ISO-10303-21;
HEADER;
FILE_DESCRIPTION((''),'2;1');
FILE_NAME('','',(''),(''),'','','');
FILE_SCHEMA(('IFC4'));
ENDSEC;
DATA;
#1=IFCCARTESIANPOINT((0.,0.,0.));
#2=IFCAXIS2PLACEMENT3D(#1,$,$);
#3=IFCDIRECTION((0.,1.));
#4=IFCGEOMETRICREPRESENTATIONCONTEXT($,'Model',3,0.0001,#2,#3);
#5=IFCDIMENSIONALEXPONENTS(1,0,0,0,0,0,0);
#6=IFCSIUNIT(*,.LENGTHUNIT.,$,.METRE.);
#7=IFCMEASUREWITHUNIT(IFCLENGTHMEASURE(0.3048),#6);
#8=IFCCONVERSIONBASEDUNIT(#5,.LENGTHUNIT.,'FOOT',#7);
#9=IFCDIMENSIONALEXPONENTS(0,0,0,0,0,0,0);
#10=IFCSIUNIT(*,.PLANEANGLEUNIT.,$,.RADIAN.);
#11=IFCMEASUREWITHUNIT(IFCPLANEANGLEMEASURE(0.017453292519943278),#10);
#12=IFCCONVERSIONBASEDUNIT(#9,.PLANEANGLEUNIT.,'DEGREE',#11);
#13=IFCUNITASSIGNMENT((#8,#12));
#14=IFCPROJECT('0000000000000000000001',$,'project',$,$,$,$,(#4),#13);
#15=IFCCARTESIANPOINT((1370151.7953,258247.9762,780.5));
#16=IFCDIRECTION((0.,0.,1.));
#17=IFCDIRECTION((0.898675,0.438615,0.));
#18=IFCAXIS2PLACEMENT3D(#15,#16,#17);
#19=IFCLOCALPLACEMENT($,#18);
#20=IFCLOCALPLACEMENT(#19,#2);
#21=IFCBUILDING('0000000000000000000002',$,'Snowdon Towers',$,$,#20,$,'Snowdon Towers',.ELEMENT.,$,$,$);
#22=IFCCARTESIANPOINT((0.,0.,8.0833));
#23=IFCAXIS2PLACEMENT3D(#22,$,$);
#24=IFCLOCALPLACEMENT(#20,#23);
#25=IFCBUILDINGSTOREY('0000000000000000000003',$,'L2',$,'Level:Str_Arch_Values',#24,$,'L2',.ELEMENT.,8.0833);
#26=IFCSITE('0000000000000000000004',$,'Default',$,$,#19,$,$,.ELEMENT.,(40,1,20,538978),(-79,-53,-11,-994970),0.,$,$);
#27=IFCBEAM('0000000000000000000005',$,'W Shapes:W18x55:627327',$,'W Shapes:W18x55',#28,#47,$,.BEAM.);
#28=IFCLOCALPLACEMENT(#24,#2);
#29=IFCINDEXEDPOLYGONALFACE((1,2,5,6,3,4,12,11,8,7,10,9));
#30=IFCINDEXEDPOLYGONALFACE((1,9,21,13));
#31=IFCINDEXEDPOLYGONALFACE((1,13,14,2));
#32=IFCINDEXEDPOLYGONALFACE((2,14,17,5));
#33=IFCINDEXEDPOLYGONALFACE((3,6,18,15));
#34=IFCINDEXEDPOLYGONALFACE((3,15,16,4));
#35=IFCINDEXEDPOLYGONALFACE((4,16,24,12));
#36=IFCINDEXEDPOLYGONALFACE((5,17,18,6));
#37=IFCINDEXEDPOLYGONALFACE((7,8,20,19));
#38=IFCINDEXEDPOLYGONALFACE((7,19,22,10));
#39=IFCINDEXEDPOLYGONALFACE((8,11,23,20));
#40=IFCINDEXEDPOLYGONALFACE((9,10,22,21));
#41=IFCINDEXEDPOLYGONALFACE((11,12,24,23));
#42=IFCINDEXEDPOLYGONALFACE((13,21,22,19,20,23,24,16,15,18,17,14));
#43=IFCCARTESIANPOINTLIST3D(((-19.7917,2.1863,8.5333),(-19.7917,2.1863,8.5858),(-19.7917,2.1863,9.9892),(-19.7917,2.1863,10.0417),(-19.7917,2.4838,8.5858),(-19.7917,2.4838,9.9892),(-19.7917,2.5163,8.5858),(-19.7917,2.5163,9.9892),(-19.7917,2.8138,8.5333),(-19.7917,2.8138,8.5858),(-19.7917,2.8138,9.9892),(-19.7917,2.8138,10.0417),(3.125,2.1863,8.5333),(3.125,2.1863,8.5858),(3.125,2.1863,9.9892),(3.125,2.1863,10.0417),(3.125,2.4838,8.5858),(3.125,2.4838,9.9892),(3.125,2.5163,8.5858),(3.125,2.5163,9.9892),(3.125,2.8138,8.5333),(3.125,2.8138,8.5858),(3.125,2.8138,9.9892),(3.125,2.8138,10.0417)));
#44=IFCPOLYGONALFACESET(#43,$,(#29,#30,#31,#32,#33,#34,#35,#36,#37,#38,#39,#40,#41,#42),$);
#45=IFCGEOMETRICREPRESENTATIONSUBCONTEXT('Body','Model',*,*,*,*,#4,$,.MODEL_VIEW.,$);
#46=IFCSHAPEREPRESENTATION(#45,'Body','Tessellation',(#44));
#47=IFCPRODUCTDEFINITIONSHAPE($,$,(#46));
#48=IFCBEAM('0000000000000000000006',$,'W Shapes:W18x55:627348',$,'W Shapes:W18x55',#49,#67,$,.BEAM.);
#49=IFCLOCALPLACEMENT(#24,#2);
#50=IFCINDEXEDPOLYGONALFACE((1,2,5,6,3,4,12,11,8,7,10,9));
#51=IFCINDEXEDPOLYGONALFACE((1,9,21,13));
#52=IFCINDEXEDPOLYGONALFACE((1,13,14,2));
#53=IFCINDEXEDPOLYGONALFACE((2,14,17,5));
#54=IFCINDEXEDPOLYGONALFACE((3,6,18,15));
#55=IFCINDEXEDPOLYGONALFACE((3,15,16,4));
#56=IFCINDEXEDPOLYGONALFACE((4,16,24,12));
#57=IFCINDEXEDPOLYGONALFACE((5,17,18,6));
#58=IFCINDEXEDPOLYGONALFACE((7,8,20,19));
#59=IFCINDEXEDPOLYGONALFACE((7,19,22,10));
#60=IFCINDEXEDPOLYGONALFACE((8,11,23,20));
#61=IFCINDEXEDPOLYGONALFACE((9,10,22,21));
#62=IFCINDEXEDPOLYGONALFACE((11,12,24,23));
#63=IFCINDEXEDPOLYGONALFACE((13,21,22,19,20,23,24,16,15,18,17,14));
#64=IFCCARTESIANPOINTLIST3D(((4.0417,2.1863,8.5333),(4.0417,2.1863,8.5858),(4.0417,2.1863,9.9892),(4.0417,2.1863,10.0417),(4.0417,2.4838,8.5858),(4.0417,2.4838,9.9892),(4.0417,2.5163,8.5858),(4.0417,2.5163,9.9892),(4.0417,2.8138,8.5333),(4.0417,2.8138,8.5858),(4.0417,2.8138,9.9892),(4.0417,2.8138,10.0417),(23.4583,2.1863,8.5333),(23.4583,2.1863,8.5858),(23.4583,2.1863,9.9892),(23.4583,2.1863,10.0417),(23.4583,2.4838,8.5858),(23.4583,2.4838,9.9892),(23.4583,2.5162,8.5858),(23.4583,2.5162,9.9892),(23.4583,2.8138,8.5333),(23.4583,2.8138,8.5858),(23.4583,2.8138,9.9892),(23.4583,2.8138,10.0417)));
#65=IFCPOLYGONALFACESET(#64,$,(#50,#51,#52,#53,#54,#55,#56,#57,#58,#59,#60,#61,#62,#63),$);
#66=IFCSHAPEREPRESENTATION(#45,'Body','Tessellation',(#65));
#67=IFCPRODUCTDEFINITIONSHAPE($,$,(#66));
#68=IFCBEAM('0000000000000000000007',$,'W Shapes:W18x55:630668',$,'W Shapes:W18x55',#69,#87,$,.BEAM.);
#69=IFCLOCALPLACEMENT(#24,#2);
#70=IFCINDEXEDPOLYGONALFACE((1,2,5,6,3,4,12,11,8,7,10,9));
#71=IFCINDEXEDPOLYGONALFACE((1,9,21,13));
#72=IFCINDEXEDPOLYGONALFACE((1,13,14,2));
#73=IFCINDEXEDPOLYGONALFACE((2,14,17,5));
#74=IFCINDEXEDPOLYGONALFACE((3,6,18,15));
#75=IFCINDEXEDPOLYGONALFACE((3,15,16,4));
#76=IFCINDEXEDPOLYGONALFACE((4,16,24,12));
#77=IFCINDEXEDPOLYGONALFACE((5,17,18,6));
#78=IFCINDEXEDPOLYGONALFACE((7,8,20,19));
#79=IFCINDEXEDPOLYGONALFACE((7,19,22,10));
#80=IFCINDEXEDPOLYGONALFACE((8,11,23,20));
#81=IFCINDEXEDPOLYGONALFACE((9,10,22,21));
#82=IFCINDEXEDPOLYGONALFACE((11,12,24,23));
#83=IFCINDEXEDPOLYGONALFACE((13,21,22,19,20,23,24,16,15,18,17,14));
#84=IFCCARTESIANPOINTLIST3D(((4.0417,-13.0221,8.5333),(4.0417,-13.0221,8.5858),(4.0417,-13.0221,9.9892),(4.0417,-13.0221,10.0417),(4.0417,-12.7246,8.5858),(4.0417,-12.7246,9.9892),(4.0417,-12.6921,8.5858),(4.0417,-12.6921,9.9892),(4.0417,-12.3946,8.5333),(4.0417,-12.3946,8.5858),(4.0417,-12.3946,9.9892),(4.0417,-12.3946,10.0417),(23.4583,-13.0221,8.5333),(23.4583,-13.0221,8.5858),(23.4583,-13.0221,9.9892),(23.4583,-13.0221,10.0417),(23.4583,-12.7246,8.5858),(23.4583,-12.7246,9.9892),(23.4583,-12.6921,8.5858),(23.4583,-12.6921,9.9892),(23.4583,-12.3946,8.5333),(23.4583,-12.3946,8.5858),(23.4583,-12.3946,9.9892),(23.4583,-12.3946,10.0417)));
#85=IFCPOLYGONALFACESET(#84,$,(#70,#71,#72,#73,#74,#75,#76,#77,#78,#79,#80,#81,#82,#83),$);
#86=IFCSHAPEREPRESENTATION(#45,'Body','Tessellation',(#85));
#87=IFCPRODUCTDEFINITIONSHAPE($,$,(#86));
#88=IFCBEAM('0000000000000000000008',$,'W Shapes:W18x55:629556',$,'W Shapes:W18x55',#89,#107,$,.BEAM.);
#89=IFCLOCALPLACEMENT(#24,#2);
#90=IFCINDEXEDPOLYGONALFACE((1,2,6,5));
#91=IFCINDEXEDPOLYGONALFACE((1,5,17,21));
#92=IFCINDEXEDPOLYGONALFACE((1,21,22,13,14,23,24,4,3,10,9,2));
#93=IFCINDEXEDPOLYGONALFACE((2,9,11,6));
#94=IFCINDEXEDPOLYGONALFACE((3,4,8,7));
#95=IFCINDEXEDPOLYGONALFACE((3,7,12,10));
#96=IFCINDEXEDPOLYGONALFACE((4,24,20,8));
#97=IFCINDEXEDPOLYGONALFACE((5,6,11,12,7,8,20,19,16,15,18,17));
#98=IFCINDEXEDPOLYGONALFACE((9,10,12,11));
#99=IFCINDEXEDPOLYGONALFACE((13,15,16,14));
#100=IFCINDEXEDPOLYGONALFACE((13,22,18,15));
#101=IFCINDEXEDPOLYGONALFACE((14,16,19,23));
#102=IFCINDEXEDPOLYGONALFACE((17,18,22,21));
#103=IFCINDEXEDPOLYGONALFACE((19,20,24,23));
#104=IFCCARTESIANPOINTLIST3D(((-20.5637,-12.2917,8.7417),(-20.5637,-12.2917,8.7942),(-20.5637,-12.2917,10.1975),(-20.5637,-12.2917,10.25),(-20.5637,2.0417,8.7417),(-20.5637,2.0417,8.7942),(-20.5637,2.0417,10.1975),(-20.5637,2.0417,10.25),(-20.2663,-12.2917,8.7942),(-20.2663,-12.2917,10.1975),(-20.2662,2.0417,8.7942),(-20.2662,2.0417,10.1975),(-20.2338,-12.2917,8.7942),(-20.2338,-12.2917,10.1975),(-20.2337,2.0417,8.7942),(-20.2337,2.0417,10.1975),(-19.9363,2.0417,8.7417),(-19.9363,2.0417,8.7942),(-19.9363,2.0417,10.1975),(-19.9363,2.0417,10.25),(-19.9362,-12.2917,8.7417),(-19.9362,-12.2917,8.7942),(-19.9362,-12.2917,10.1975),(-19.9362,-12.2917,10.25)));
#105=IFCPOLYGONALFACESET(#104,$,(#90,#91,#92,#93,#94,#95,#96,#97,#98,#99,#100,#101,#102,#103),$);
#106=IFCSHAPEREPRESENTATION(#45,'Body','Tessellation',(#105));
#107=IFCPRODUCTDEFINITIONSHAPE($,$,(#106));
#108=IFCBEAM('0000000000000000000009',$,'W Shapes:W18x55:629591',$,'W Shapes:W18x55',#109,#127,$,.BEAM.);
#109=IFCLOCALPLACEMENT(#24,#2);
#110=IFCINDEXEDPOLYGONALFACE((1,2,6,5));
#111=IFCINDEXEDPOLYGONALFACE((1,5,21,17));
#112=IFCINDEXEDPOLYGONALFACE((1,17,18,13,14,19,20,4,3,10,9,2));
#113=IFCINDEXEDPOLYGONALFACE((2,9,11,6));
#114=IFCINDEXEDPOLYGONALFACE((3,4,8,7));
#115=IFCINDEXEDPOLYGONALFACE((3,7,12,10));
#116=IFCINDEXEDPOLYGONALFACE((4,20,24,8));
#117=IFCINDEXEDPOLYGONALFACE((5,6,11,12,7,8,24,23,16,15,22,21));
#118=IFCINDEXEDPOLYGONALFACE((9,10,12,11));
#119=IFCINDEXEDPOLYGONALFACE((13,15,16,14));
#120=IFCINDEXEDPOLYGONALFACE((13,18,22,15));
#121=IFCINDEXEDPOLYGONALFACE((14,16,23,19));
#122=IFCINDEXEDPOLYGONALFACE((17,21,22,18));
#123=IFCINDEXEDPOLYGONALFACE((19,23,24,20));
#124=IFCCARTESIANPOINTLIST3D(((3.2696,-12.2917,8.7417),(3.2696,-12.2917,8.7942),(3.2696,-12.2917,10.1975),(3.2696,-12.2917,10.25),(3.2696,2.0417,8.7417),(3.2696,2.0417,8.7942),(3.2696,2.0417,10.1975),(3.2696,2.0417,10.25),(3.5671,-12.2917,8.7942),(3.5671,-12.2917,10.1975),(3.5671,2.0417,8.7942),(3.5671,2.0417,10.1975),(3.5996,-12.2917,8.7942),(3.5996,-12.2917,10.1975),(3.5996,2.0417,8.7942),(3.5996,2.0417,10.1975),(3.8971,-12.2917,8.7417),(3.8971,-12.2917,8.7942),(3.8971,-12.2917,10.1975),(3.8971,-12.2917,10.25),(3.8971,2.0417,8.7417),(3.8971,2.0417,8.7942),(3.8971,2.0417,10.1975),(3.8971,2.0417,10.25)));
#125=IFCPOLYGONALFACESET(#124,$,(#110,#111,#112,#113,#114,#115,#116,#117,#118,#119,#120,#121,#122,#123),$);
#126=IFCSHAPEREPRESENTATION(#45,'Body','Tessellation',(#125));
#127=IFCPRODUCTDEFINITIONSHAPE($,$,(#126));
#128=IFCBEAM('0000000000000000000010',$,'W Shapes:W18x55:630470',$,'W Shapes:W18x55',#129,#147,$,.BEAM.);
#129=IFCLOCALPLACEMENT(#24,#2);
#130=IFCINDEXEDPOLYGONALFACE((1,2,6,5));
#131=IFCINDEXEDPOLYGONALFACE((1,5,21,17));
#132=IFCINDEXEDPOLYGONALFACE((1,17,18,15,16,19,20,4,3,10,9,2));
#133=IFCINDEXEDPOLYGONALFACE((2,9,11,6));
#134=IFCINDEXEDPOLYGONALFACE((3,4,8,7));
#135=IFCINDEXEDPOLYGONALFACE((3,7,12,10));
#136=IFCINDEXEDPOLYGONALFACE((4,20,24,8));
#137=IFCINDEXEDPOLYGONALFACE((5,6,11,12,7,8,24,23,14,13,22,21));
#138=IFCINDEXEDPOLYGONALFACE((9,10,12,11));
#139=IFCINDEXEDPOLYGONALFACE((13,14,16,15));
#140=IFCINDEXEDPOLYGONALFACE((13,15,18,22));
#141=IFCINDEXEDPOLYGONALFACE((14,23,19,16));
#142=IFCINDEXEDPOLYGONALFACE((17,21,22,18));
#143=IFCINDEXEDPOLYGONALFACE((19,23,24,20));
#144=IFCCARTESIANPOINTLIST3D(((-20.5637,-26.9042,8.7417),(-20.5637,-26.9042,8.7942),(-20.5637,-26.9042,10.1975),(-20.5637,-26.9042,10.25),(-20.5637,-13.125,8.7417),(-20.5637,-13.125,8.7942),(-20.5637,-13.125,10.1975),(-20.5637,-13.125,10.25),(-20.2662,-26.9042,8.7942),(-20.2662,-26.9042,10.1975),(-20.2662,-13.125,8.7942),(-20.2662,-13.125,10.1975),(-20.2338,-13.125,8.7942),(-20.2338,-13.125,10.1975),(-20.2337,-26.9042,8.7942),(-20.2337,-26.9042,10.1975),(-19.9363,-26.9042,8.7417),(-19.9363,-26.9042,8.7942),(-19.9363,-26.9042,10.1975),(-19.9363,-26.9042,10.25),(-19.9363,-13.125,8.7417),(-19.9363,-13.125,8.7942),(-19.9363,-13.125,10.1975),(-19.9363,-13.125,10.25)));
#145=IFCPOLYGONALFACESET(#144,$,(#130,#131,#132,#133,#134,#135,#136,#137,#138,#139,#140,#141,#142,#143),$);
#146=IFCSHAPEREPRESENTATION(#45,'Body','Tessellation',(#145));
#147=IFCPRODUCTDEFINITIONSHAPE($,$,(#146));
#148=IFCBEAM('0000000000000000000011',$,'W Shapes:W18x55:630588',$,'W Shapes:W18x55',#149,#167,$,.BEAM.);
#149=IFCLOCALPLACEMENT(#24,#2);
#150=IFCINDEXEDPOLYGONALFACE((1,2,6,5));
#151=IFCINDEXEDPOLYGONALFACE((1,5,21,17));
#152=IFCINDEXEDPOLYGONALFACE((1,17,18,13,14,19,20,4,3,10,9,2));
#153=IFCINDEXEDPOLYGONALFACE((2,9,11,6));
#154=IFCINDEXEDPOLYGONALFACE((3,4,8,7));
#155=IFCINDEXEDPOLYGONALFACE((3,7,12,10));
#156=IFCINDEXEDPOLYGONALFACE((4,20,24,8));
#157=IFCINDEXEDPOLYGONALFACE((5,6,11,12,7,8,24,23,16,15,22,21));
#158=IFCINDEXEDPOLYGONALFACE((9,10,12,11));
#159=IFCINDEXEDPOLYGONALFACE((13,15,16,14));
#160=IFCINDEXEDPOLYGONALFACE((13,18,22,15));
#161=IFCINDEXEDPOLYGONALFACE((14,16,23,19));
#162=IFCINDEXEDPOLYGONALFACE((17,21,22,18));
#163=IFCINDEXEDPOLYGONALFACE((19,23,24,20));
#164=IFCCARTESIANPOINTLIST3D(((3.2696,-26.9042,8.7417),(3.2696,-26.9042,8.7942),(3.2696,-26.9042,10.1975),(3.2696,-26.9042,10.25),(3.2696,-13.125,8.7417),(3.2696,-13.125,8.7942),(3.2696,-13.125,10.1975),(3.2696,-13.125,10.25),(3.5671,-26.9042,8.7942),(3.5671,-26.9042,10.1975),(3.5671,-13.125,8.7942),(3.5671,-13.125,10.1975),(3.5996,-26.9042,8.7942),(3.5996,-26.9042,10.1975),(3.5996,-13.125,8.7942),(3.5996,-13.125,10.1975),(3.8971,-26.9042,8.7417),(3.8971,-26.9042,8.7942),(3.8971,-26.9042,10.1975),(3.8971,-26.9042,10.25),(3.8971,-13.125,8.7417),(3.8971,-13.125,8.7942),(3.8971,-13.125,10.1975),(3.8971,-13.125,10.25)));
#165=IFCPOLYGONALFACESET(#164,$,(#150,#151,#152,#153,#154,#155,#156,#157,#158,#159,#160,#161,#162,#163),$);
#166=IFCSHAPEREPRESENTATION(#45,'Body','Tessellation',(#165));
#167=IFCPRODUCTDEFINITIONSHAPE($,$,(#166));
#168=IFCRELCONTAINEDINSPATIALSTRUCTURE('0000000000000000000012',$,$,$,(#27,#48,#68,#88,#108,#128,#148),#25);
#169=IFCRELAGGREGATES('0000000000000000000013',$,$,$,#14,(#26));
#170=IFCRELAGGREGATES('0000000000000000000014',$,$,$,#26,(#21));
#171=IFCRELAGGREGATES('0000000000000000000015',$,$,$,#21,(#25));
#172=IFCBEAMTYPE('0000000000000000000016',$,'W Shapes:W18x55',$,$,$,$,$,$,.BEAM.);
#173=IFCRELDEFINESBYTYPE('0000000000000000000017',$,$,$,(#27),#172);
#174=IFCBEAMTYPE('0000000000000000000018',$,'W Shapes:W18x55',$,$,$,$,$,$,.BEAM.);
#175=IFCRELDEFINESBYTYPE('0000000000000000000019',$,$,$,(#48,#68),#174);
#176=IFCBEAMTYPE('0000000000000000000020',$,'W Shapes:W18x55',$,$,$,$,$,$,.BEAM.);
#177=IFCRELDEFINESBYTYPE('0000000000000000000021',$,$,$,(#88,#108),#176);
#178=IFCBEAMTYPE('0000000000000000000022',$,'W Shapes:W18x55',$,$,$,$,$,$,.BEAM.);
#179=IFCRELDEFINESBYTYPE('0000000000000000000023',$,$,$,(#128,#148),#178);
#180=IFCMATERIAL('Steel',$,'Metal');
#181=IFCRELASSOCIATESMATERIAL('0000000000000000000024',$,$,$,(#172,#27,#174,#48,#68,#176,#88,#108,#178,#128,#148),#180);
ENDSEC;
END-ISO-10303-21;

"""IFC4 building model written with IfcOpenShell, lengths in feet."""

from ifc_helpers import new_model, entity, si_unit, converted_unit, direction, frame, origin, place, context, subcontext, project, spatial, indexed_curve, outline, extrude, source, transform, mapped, material, type_object, type_shapes, element, save


model = new_model("IFC4")

# Units and contexts
model_context = context("Model", 3, precision=0.0001, world=origin(), true_north=direction((0.0, 1.0)))
body_context = subcontext(model_context, "Body", "Model", "MODEL_VIEW")
ifc_project = project(units=[converted_unit("LENGTHUNIT", "FOOT", entity("IfcLengthMeasure", 0.3048), si_unit("LENGTHUNIT", "METRE"), dimensions=[1, 0, 0, 0, 0, 0, 0]), converted_unit("PLANEANGLEUNIT", "DEGREE", entity("IfcPlaneAngleMeasure", 0.017453292519943278), si_unit("PLANEANGLEUNIT", "RADIAN"), dimensions=[0, 0, 0, 0, 0, 0, 0])], contexts=[model_context])

# Site, building, storey
site_placement = place(None, frame((1370151.7953, 258247.9762, 780.5), z_axis=(0.0, 0.0, 1.0), x_axis=(0.898675, 0.438615, 0.0)))
site = spatial("IfcSite", under=ifc_project, at=site_placement, Name="Default", CompositionType="ELEMENT", RefLatitude=(40, 1, 20, 538978), RefLongitude=(-79, -53, -11, -994970), RefElevation=0.0)
building_placement = place(site_placement, origin())
building = spatial("IfcBuilding", under=site, at=building_placement, Name="Snowdon Towers", LongName="Snowdon Towers", CompositionType="ELEMENT")
storey_placement = place(building_placement, frame((0.0, 0.0, 8.0833)))
storey = spatial("IfcBuildingStorey", under=building, at=storey_placement, Name="L2", ObjectType="Level:Str_Arch_Values", LongName="L2", CompositionType="ELEMENT", Elevation=8.0833)

# Beams
ifc_material_1 = material(Name="Steel", Category="Metal")
beam_type_1 = type_object("IfcBeamType", Name="W Shapes:W18x55", PredefinedType="BEAM", material=ifc_material_1)
shared_shape_1 = source(origin(), body_context, "Body", "SweptSolid", [
    extrude(outline(indexed_curve([(-0.3138, -0.7017), (-0.3138, -0.7542), (0.3138, -0.7542), (0.3138, -0.7017), (0.0162, -0.7017), (0.0162, 0.7017), (0.3138, 0.7017), (0.3138, 0.7542), (-0.3137, 0.7542), (-0.3137, 0.7017), (-0.0163, 0.7017), (-0.0163, -0.7017), (-0.3138, -0.7017)], self_intersect=False)), frame((-11.5417, 0.0, 0.0), z_axis=(-1.0, 0.0, 0.0), x_axis=(0.0, -1.0, 0.0)), (0.0, 0.0, -1.0), 22.9167),
])
type_shapes(beam_type_1, [shared_shape_1])
beam_1_placement = place(storey_placement, frame((-8.25, 2.5, 9.2875)))
element("IfcBeam", 1, at=beam_1_placement, inside=storey, type_object=beam_type_1, material=ifc_material_1, Name="W Shapes:W18x55:627327", ObjectType="W Shapes:W18x55", PredefinedType="BEAM", context=body_context, shape_type="MappedRepresentation", body=[
    mapped(shared_shape_1, transform((0.0, 0.0, 0.0), scale=1.0)),
])
beam_type_2 = type_object("IfcBeamType", Name="W Shapes:W18x55", PredefinedType="BEAM", material=ifc_material_1)
shared_shape_2 = source(origin(), body_context, "Body", "SweptSolid", [
    extrude(outline(indexed_curve([(-0.3138, -0.7017), (-0.3138, -0.7542), (0.3138, -0.7542), (0.3138, -0.7017), (0.0162, -0.7017), (0.0162, 0.7017), (0.3138, 0.7017), (0.3138, 0.7542), (-0.3137, 0.7542), (-0.3137, 0.7017), (-0.0163, 0.7017), (-0.0163, -0.7017), (-0.3138, -0.7017)], self_intersect=False)), frame((-9.7917, 0.0, 0.0), z_axis=(-1.0, 0.0, 0.0), x_axis=(0.0, -1.0, 0.0)), (0.0, 0.0, -1.0), 19.4167),
])
type_shapes(beam_type_2, [shared_shape_2])
for number, where, name in (
    (2, (13.8333, 2.5, 9.2875), "W Shapes:W18x55:627348"),
    (3, (13.8333, -12.7083, 9.2875), "W Shapes:W18x55:630668"),
):
    element("IfcBeam", number, at=place(storey_placement, frame(where)), inside=storey, type_object=beam_type_2, material=ifc_material_1, Name=name, ObjectType="W Shapes:W18x55", PredefinedType="BEAM", context=body_context, shape_type="MappedRepresentation", body=[
        mapped(shared_shape_2, transform((0.0, 0.0, 0.0), scale=1.0)),
    ])
beam_type_3 = type_object("IfcBeamType", Name="W Shapes:W18x55", PredefinedType="BEAM", material=ifc_material_1)
shared_shape_3 = source(origin(), body_context, "Body", "SweptSolid", [
    extrude(outline(indexed_curve([(-0.3138, -0.7017), (-0.3138, -0.7542), (0.3138, -0.7542), (0.3138, -0.7017), (0.0162, -0.7017), (0.0162, 0.7017), (0.3138, 0.7017), (0.3138, 0.7542), (-0.3137, 0.7542), (-0.3137, 0.7017), (-0.0163, 0.7017), (-0.0163, -0.7017), (-0.3138, -0.7017)], self_intersect=False)), frame((-7.1458, 0.0, 0.0), z_axis=(-1.0, 0.0, 0.0), x_axis=(0.0, -1.0, 0.0)), (0.0, 0.0, -1.0), 14.3333),
])
type_shapes(beam_type_3, [shared_shape_3])
for number, where, z_axis, x_axis, name in (
    (4, (-20.25, -5.1042, 9.4958), (0.0, 0.0, 1.0), (0.0, -1.0, 0.0), "W Shapes:W18x55:629556"),
    (5, (3.5833, -5.1042, 9.4958), (0.0, 0.0, 1.0), (0.0, -1.0, 0.0), "W Shapes:W18x55:629591"),
):
    element("IfcBeam", number, at=place(storey_placement, frame(where, z_axis=z_axis, x_axis=x_axis)), inside=storey, type_object=beam_type_3, material=ifc_material_1, Name=name, ObjectType="W Shapes:W18x55", PredefinedType="BEAM", context=body_context, shape_type="MappedRepresentation", body=[
        mapped(shared_shape_3, transform((0.0, 0.0, 0.0), scale=1.0)),
    ])
beam_type_4 = type_object("IfcBeamType", Name="W Shapes:W18x55", PredefinedType="BEAM", material=ifc_material_1)
shared_shape_4 = source(origin(), body_context, "Body", "SweptSolid", [
    extrude(outline(indexed_curve([(-0.3138, -0.7017), (-0.3138, -0.7542), (0.3138, -0.7542), (0.3138, -0.7017), (0.0162, -0.7017), (0.0162, 0.7017), (0.3138, 0.7017), (0.3138, 0.7542), (-0.3137, 0.7542), (-0.3137, 0.7017), (-0.0163, 0.7017), (-0.0163, -0.7017), (-0.3138, -0.7017)], self_intersect=False)), frame((-7.2292, 0.0, 0.0), z_axis=(-1.0, 0.0, 0.0), x_axis=(0.0, -1.0, 0.0)), (0.0, 0.0, -1.0), 13.7792),
])
type_shapes(beam_type_4, [shared_shape_4])
for number, where, z_axis, x_axis, name in (
    (6, (-20.25, -20.3542, 9.4958), (0.0, 0.0, 1.0), (0.0, -1.0, 0.0), "W Shapes:W18x55:630470"),
    (7, (3.5833, -20.3542, 9.4958), (0.0, 0.0, 1.0), (0.0, -1.0, 0.0), "W Shapes:W18x55:630588"),
):
    element("IfcBeam", number, at=place(storey_placement, frame(where, z_axis=z_axis, x_axis=x_axis)), inside=storey, type_object=beam_type_4, material=ifc_material_1, Name=name, ObjectType="W Shapes:W18x55", PredefinedType="BEAM", context=body_context, shape_type="MappedRepresentation", body=[
        mapped(shared_shape_4, transform((0.0, 0.0, 0.0), scale=1.0)),
    ])

save(model, "model.ifc")
